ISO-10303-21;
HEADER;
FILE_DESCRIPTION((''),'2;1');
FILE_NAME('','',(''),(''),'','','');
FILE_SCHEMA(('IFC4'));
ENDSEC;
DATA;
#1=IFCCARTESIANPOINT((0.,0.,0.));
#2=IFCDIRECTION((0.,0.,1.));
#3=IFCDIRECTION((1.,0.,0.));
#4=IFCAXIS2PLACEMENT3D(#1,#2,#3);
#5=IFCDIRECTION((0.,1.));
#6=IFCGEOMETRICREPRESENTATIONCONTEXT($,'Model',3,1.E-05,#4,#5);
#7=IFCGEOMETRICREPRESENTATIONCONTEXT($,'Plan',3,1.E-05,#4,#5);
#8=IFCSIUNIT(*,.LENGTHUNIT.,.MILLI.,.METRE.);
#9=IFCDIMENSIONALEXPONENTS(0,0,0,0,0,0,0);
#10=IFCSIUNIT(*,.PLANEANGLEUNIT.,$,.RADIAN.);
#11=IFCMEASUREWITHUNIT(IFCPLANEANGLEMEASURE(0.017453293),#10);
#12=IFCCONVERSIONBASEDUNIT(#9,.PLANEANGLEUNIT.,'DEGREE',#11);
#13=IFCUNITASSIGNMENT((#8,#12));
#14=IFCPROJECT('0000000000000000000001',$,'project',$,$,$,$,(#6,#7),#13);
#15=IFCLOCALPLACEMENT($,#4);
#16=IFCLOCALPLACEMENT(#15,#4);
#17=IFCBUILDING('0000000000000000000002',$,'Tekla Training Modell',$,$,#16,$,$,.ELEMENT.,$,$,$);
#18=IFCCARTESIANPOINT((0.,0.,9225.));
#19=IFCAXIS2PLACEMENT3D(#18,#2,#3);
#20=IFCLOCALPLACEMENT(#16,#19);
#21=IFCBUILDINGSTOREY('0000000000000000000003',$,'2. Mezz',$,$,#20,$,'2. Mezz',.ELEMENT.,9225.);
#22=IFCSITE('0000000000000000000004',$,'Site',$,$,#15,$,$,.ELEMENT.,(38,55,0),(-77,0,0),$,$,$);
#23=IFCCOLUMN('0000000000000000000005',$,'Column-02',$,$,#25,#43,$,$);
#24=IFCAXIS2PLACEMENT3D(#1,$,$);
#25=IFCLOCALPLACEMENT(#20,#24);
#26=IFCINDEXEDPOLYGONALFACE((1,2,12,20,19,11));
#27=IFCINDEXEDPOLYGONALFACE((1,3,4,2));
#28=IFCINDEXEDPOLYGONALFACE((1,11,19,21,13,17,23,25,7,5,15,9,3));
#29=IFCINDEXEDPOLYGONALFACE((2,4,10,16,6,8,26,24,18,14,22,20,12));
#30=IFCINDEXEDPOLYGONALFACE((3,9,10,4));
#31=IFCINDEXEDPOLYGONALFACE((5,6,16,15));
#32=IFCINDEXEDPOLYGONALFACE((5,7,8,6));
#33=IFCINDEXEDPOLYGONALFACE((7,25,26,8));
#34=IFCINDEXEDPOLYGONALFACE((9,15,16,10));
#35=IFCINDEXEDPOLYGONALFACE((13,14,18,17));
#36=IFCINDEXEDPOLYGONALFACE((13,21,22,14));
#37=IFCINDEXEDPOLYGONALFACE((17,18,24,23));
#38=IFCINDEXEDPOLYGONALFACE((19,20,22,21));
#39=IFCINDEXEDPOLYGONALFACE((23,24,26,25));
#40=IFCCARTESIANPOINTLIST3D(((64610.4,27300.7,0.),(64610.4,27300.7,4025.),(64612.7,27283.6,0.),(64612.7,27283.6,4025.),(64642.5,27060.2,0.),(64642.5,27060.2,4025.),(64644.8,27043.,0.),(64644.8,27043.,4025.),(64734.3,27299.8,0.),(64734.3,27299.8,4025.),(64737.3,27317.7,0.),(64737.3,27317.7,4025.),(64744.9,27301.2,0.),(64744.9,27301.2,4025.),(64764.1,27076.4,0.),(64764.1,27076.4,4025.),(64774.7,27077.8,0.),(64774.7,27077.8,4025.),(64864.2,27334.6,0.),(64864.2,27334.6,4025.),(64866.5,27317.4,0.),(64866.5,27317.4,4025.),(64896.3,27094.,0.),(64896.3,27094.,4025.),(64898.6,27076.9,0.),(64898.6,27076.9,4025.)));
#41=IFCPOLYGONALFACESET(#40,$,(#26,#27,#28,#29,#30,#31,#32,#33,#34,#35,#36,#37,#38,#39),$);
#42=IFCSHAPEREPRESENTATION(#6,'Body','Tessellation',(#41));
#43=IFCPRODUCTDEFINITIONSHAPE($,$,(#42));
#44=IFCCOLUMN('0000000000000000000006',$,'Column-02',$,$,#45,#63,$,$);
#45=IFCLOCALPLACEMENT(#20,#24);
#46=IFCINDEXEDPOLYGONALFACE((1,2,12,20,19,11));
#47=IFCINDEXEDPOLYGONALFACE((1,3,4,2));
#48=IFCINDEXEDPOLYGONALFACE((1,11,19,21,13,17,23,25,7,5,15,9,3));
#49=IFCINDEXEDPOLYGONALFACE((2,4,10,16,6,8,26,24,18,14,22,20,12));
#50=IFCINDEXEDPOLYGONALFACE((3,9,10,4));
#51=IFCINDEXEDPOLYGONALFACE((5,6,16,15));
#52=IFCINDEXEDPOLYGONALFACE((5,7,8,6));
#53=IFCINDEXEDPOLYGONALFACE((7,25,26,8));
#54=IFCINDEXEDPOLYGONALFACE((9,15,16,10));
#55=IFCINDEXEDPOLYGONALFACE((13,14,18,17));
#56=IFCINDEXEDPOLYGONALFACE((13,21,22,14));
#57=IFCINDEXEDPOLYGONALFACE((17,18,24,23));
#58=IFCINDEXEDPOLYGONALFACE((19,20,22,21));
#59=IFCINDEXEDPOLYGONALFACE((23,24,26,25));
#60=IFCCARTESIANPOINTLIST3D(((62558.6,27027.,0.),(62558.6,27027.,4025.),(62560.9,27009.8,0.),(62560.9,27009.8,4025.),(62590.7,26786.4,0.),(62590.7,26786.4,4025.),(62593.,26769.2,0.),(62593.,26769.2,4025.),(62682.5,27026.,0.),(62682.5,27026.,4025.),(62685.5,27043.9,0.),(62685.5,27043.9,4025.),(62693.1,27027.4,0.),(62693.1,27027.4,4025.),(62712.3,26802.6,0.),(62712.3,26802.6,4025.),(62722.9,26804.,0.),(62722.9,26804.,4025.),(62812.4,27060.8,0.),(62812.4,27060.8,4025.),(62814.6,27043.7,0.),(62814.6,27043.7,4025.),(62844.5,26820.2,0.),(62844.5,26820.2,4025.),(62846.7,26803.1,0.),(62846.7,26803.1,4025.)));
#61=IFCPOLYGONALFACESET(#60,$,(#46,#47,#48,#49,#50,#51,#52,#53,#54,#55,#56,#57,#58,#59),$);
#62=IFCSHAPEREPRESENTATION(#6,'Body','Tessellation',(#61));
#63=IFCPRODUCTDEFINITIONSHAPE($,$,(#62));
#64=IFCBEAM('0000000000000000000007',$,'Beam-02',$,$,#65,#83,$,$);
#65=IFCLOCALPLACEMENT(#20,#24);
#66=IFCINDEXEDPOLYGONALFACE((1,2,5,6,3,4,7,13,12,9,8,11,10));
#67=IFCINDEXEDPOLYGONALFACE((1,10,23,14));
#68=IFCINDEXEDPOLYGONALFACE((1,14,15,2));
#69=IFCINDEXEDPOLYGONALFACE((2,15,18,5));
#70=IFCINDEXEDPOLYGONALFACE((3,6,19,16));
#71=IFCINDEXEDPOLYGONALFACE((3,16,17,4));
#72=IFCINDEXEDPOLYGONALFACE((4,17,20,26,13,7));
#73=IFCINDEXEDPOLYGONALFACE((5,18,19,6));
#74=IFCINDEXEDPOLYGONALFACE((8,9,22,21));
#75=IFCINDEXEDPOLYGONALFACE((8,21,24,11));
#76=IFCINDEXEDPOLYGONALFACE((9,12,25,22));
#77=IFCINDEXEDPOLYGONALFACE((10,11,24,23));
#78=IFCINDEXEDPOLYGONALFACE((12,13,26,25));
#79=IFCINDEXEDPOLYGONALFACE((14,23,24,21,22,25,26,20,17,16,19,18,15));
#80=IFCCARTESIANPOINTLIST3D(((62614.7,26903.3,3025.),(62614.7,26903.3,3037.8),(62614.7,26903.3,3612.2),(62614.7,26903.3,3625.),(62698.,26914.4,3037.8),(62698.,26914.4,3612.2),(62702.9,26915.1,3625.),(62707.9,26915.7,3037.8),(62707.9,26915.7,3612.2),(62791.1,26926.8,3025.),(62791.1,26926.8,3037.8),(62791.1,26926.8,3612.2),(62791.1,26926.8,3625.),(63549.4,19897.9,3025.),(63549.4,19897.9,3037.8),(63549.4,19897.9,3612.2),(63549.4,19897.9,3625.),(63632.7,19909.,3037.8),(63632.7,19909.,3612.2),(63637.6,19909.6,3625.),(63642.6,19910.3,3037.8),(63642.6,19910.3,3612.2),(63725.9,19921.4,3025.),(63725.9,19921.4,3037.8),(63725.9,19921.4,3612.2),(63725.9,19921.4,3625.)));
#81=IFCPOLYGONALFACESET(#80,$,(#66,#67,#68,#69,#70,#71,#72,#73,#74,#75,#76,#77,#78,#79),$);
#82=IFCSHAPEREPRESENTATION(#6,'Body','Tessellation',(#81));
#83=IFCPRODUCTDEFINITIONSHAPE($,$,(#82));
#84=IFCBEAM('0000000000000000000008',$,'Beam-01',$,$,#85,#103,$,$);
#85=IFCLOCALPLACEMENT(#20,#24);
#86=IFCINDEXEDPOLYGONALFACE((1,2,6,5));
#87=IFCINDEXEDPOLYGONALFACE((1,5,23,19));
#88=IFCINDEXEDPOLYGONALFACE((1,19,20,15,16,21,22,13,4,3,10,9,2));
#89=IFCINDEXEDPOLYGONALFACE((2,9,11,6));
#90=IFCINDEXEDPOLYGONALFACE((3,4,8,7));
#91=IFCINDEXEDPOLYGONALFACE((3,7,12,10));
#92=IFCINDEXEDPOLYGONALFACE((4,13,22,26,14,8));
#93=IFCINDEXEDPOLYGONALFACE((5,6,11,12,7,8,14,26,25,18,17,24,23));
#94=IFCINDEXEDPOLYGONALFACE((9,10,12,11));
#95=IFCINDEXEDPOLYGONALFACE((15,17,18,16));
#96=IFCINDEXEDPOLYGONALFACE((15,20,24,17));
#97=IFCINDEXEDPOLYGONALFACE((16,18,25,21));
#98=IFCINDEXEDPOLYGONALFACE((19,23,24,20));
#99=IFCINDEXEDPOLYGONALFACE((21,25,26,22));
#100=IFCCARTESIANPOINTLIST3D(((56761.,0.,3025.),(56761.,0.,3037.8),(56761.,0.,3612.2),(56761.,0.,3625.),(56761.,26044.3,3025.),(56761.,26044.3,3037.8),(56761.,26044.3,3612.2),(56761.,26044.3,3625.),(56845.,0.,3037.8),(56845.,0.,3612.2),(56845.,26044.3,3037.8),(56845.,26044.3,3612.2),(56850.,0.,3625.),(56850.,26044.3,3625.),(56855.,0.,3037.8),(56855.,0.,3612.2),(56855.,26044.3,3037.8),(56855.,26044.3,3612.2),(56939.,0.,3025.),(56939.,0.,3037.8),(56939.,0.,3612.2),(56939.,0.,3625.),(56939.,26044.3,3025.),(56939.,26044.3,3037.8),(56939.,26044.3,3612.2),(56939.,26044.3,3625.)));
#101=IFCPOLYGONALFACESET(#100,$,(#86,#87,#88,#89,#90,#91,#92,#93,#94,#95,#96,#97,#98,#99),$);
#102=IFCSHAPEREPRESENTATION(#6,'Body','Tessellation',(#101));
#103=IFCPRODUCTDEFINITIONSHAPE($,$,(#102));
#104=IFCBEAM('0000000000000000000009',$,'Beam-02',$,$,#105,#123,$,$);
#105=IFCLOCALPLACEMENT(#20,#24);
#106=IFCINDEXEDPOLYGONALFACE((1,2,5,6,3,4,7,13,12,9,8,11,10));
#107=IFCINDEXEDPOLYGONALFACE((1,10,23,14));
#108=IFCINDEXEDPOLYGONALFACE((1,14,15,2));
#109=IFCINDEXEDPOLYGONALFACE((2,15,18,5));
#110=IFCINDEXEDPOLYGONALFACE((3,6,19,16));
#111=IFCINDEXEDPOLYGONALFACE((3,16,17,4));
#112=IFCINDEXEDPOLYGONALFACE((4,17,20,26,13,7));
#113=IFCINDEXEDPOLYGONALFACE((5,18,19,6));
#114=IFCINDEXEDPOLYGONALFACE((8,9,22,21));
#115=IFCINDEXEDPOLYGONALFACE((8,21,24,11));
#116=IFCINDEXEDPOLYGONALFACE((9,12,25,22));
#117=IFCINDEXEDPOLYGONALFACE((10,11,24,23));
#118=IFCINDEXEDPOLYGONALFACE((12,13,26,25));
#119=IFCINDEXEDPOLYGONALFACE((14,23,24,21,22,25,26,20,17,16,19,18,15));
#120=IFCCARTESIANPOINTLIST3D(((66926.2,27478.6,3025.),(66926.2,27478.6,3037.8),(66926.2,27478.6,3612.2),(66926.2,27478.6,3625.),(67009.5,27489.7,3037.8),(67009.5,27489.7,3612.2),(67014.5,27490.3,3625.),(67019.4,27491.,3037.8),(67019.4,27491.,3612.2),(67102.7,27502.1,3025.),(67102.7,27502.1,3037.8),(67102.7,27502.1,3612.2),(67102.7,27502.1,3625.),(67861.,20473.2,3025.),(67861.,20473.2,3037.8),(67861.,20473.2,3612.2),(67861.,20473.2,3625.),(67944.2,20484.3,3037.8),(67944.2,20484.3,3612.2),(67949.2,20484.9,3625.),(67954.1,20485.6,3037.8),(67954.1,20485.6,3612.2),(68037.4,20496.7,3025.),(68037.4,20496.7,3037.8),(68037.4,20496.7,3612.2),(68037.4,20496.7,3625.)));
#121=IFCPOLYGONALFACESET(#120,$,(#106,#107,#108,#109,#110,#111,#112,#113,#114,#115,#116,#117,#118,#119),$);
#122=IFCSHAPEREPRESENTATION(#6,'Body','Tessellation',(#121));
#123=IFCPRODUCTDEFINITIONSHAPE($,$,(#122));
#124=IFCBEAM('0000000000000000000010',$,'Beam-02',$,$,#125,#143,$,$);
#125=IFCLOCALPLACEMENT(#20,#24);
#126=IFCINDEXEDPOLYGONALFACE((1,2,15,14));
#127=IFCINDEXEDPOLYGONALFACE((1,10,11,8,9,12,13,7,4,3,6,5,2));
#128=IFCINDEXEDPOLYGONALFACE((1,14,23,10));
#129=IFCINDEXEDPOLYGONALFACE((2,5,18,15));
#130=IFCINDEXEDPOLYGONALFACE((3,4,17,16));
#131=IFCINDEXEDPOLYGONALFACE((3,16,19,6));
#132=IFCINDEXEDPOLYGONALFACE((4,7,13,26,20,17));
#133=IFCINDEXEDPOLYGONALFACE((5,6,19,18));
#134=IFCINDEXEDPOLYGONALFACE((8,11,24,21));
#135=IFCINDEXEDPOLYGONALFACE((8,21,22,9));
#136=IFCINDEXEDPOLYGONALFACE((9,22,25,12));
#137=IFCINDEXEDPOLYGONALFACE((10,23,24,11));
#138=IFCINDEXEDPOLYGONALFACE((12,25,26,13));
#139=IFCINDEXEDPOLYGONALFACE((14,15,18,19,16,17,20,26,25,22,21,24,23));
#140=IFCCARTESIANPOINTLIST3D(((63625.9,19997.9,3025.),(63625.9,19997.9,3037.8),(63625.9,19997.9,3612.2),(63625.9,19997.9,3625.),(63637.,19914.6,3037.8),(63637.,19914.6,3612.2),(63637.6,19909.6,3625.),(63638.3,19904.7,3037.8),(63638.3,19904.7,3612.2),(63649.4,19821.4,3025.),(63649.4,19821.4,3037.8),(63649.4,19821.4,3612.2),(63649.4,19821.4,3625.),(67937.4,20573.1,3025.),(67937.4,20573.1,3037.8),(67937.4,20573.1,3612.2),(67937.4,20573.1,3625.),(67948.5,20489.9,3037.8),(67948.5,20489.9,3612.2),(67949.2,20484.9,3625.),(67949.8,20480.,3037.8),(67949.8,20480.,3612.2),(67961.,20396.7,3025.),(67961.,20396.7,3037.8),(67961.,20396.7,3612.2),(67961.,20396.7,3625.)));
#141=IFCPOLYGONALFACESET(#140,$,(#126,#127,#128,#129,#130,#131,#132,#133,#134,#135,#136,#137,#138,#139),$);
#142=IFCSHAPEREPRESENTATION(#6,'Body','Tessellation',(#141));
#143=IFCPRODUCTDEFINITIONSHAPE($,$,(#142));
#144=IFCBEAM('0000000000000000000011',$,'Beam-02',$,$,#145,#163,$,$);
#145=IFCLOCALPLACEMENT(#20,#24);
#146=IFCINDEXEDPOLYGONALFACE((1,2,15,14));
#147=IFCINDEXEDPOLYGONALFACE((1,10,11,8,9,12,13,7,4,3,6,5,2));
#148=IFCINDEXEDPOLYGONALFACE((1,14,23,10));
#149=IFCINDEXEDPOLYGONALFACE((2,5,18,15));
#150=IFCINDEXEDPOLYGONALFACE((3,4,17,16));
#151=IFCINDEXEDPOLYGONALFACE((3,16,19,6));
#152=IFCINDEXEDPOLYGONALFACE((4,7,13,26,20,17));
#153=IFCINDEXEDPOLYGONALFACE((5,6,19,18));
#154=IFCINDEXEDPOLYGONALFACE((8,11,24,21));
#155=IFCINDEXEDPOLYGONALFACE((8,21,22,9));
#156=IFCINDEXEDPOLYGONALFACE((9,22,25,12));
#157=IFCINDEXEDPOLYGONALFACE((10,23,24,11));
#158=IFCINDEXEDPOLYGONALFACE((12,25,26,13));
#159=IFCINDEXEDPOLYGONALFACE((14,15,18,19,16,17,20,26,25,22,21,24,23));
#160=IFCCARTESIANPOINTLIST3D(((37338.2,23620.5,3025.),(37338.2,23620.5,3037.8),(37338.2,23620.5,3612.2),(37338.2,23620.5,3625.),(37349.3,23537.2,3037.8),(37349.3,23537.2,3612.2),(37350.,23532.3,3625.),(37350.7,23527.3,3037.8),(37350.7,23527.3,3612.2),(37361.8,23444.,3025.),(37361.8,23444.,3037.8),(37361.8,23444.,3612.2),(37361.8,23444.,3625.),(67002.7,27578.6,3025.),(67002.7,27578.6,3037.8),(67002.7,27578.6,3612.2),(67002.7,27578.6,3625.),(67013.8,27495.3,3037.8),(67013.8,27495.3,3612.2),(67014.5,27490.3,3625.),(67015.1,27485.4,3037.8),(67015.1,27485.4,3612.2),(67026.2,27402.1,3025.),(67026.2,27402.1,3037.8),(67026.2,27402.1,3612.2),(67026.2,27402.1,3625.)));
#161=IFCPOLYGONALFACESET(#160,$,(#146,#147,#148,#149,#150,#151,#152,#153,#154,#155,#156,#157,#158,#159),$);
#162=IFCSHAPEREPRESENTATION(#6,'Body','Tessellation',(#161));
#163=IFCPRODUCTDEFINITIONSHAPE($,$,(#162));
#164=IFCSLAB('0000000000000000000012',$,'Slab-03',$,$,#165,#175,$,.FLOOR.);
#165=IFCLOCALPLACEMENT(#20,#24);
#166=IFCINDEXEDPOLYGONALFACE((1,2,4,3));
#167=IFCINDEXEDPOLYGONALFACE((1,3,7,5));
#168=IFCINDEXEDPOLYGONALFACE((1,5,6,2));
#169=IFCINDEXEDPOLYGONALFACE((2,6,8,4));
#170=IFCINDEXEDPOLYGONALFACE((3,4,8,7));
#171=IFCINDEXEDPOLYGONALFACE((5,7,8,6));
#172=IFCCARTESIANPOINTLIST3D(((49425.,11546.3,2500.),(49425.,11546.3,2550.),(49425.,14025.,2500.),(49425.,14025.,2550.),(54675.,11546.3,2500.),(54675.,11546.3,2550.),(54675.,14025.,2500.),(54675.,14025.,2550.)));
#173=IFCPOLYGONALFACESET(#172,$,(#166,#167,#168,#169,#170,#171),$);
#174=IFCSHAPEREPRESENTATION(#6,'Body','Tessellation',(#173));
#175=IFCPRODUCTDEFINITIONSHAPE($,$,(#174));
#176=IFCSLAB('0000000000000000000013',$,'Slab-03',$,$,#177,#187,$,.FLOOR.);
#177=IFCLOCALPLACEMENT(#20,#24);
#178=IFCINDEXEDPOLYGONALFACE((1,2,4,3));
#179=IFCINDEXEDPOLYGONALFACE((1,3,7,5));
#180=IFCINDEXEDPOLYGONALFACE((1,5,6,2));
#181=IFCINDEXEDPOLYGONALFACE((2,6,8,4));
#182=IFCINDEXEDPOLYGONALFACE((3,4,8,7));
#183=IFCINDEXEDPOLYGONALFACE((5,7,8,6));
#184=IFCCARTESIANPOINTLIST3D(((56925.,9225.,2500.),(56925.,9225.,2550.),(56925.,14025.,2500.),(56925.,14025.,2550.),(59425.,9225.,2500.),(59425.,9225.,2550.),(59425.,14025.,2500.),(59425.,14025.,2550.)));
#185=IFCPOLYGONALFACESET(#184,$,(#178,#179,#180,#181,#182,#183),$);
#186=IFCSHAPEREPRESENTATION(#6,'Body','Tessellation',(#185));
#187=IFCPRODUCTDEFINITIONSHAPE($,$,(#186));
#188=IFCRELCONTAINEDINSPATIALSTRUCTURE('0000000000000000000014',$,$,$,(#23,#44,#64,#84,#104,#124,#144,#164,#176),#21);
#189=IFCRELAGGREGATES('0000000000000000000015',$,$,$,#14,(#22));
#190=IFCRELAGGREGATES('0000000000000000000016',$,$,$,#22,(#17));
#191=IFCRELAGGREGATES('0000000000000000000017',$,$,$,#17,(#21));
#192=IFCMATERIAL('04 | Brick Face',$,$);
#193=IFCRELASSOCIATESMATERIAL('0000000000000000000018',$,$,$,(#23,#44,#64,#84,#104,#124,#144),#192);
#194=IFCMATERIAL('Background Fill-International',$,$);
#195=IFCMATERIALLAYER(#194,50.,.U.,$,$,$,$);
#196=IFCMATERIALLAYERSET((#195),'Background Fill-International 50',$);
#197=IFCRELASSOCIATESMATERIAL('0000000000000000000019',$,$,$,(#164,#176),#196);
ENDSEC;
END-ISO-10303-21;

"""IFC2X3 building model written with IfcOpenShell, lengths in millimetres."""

from ifc_helpers import new_model, entity, si_unit, converted_unit, direction, frame, origin_with_axes, place, context, project, spatial, polyline, outline, extrude, material, layer, layer_set, layer_usage, element, save


model = new_model("IFC2X3")

# Units and contexts
model_context = context("Model", 3, precision=1e-05, world=origin_with_axes(), true_north=direction((0.0, 1.0)))
plan_context = context("Plan", 3, precision=1e-05, world=origin_with_axes(), true_north=direction((0.0, 1.0)))
ifc_project = project(units=[si_unit("LENGTHUNIT", "METRE", prefix="MILLI"), converted_unit("PLANEANGLEUNIT", "DEGREE", entity("IfcPlaneAngleMeasure", 0.017453293), si_unit("PLANEANGLEUNIT", "RADIAN"), dimensions=[0, 0, 0, 0, 0, 0, 0])], contexts=[model_context, plan_context])

# Site, building, storey
site_placement = place(None, origin_with_axes())
site = spatial("IfcSite", under=ifc_project, at=site_placement, Name="Site", CompositionType="ELEMENT", RefLatitude=(38, 55, 0), RefLongitude=(-77, 0, 0))
building_placement = place(site_placement, origin_with_axes())
building = spatial("IfcBuilding", under=site, at=building_placement, Name="Tekla Training Modell", CompositionType="ELEMENT")
storey_placement = place(building_placement, frame((0.0, 0.0, 9225.0), z_axis=(0.0, 0.0, 1.0), x_axis=(1.0, 0.0, 0.0)))
storey = spatial("IfcBuildingStorey", under=building, at=storey_placement, Name="2. Mezz", LongName="2. Mezz", CompositionType="ELEMENT", Elevation=9225.0)

# Columns
ifc_material_1 = material(Name="04 | Brick Face")
for number, where, z_axis, x_axis, name in (
    (1, (64754.5, 27188.8, 0.0), (0.0, 0.0, 1.0), (0.991216, 0.132256, 0.0), "Column-02"),
    (2, (62702.7, 26915.0, 0.0), (0.0, 0.0, 1.0), (0.991216, 0.132256, 0.0), "Column-02"),
):
    element("IfcColumn", number, at=place(storey_placement, frame(where, z_axis=z_axis, x_axis=x_axis)), inside=storey, material=ifc_material_1, Name=name, context=model_context, shape_type="SweptSolid", body=[
        extrude(outline(polyline([(0.0, 130.0), (-128.0, 130.0), (-128.0, 112.7), (-5.3, 112.7), (-5.3, -112.7), (-128.0, -112.7), (-128.0, -130.0), (128.0, -130.0), (128.0, -112.7), (5.3, -112.7), (5.3, 112.7), (128.0, 112.7), (128.0, 130.0), (0.0, 130.0)])), origin_with_axes(), (0.0, 0.0, 1.0), 4025.0),
    ])

# Beams
beam_1_placement = place(storey_placement, frame((63637.6, 19909.6, 3325.0), z_axis=(0.0, 0.0, 1.0), x_axis=(0.991216, 0.132256, 0.0)))
element("IfcBeam", 3, at=beam_1_placement, inside=storey, material=ifc_material_1, Name="Beam-02", context=model_context, shape_type="SweptSolid", body=[
    extrude(outline(polyline([(0.0, 300.0), (-89.0, 300.0), (-89.0, 287.2), (-5.0, 287.2), (-5.0, -287.2), (-89.0, -287.2), (-89.0, -300.0), (89.0, -300.0), (89.0, -287.2), (5.0, -287.2), (5.0, 287.2), (89.0, 287.2), (89.0, 300.0), (0.0, 300.0)])), frame((0.0, 7067.5, 0.0), z_axis=(0.0, -1.0, 0.0), x_axis=(1.0, 0.0, 0.0)), (0.0, 0.0, 1.0), 7067.5),
])
beam_2_placement = place(storey_placement, frame((56850.0, 26044.3, 3325.0), z_axis=(0.0, 0.0, 1.0), x_axis=(-1.0, 0.0, 0.0)))
element("IfcBeam", 4, at=beam_2_placement, inside=storey, material=ifc_material_1, Name="Beam-01", context=model_context, shape_type="SweptSolid", body=[
    extrude(outline(polyline([(0.0, 300.0), (-89.0, 300.0), (-89.0, 287.2), (-5.0, 287.2), (-5.0, -287.2), (-89.0, -287.2), (-89.0, -300.0), (89.0, -300.0), (89.0, -287.2), (5.0, -287.2), (5.0, 287.2), (89.0, 287.2), (89.0, 300.0), (0.0, 300.0)])), frame((0.0, 26044.3, 0.0), z_axis=(0.0, -1.0, 0.0), x_axis=(1.0, 0.0, 0.0)), (0.0, 0.0, 1.0), 26044.3),
])
beam_3_placement = place(storey_placement, frame((67949.2, 20484.9, 3325.0), z_axis=(0.0, 0.0, 1.0), x_axis=(0.991216, 0.132256, 0.0)))
element("IfcBeam", 5, at=beam_3_placement, inside=storey, material=ifc_material_1, Name="Beam-02", context=model_context, shape_type="SweptSolid", body=[
    extrude(outline(polyline([(0.0, 300.0), (-89.0, 300.0), (-89.0, 287.2), (-5.0, 287.2), (-5.0, -287.2), (-89.0, -287.2), (-89.0, -300.0), (89.0, -300.0), (89.0, -287.2), (5.0, -287.2), (5.0, 287.2), (89.0, 287.2), (89.0, 300.0), (0.0, 300.0)])), frame((0.0, 7067.5, 0.0), z_axis=(0.0, -1.0, 0.0), x_axis=(1.0, 0.0, 0.0)), (0.0, 0.0, 1.0), 7067.5),
])
beam_4_placement = place(storey_placement, frame((67949.2, 20484.9, 3325.0), z_axis=(0.0, 0.0, 1.0), x_axis=(-0.132257, 0.991216, 0.0)))
element("IfcBeam", 6, at=beam_4_placement, inside=storey, material=ifc_material_1, Name="Beam-02", context=model_context, shape_type="SweptSolid", body=[
    extrude(outline(polyline([(0.0, 300.0), (-89.0, 300.0), (-89.0, 287.2), (-5.0, 287.2), (-5.0, -287.2), (-89.0, -287.2), (-89.0, -300.0), (89.0, -300.0), (89.0, -287.2), (5.0, -287.2), (5.0, 287.2), (89.0, 287.2), (89.0, 300.0), (0.0, 300.0)])), frame((0.0, 4349.8, 0.0), z_axis=(0.0, -1.0, 0.0), x_axis=(1.0, 0.0, 0.0)), (0.0, 0.0, 1.0), 4349.8),
])
beam_5_placement = place(storey_placement, frame((67014.5, 27490.3, 3325.0), z_axis=(0.0, 0.0, 1.0), x_axis=(-0.132256, 0.991216, 0.0)))
element("IfcBeam", 7, at=beam_5_placement, inside=storey, material=ifc_material_1, Name="Beam-02", context=model_context, shape_type="SweptSolid", body=[
    extrude(outline(polyline([(0.0, 300.0), (-89.0, 300.0), (-89.0, 287.2), (-5.0, 287.2), (-5.0, -287.2), (-89.0, -287.2), (-89.0, -300.0), (89.0, -300.0), (89.0, -287.2), (5.0, -287.2), (5.0, 287.2), (89.0, 287.2), (89.0, 300.0), (0.0, 300.0)])), frame((0.0, 29927.4, 0.0), z_axis=(0.0, -1.0, 0.0), x_axis=(1.0, 0.0, 0.0)), (0.0, 0.0, 1.0), 29927.4),
])

# Slabs
ifc_material_2 = material(Name="Background Fill-International")
ifc_layer_1 = layer(ifc_material_2, 50.0, ventilated="UNKNOWN")
ifc_layer_set_1 = layer_set([ifc_layer_1], Name="Background Fill-International 50")
ifc_layer_usage_1 = layer_usage(ifc_layer_set_1, "AXIS3", "NEGATIVE", 50.0)
slab_1_placement = place(storey_placement, frame((54675.0, 14025.0, 2500.0), z_axis=(0.0, 0.0, 1.0), x_axis=(-1.0, 0.0, 0.0)))
element("IfcSlab", 8, at=slab_1_placement, inside=storey, material=ifc_layer_usage_1, Name="Slab-03", PredefinedType="FLOOR", context=model_context, shape_type="SweptSolid", body=[
    extrude(outline(polyline([(0.0, 0.0), (5250.0, 0.0), (5250.0, 2478.7), (0.0, 2478.7), (0.0, 0.0)])), origin_with_axes(), (0.0, 0.0, 1.0), 50.0),
])
ifc_layer_usage_2 = layer_usage(ifc_layer_set_1, "AXIS3", "NEGATIVE", 50.0)
slab_2_placement = place(storey_placement, frame((59425.0, 14025.0, 2500.0), z_axis=(0.0, 0.0, 1.0), x_axis=(0.0, -1.0, 0.0)))
element("IfcSlab", 9, at=slab_2_placement, inside=storey, material=ifc_layer_usage_2, Name="Slab-03", PredefinedType="FLOOR", context=model_context, shape_type="SweptSolid", body=[
    extrude(outline(polyline([(0.0, 0.0), (4800.0, 0.0), (4800.0, -2500.0), (0.0, -2500.0), (0.0, 0.0)])), origin_with_axes(), (0.0, 0.0, 1.0), 50.0),
])

save(model, "model.ifc")
